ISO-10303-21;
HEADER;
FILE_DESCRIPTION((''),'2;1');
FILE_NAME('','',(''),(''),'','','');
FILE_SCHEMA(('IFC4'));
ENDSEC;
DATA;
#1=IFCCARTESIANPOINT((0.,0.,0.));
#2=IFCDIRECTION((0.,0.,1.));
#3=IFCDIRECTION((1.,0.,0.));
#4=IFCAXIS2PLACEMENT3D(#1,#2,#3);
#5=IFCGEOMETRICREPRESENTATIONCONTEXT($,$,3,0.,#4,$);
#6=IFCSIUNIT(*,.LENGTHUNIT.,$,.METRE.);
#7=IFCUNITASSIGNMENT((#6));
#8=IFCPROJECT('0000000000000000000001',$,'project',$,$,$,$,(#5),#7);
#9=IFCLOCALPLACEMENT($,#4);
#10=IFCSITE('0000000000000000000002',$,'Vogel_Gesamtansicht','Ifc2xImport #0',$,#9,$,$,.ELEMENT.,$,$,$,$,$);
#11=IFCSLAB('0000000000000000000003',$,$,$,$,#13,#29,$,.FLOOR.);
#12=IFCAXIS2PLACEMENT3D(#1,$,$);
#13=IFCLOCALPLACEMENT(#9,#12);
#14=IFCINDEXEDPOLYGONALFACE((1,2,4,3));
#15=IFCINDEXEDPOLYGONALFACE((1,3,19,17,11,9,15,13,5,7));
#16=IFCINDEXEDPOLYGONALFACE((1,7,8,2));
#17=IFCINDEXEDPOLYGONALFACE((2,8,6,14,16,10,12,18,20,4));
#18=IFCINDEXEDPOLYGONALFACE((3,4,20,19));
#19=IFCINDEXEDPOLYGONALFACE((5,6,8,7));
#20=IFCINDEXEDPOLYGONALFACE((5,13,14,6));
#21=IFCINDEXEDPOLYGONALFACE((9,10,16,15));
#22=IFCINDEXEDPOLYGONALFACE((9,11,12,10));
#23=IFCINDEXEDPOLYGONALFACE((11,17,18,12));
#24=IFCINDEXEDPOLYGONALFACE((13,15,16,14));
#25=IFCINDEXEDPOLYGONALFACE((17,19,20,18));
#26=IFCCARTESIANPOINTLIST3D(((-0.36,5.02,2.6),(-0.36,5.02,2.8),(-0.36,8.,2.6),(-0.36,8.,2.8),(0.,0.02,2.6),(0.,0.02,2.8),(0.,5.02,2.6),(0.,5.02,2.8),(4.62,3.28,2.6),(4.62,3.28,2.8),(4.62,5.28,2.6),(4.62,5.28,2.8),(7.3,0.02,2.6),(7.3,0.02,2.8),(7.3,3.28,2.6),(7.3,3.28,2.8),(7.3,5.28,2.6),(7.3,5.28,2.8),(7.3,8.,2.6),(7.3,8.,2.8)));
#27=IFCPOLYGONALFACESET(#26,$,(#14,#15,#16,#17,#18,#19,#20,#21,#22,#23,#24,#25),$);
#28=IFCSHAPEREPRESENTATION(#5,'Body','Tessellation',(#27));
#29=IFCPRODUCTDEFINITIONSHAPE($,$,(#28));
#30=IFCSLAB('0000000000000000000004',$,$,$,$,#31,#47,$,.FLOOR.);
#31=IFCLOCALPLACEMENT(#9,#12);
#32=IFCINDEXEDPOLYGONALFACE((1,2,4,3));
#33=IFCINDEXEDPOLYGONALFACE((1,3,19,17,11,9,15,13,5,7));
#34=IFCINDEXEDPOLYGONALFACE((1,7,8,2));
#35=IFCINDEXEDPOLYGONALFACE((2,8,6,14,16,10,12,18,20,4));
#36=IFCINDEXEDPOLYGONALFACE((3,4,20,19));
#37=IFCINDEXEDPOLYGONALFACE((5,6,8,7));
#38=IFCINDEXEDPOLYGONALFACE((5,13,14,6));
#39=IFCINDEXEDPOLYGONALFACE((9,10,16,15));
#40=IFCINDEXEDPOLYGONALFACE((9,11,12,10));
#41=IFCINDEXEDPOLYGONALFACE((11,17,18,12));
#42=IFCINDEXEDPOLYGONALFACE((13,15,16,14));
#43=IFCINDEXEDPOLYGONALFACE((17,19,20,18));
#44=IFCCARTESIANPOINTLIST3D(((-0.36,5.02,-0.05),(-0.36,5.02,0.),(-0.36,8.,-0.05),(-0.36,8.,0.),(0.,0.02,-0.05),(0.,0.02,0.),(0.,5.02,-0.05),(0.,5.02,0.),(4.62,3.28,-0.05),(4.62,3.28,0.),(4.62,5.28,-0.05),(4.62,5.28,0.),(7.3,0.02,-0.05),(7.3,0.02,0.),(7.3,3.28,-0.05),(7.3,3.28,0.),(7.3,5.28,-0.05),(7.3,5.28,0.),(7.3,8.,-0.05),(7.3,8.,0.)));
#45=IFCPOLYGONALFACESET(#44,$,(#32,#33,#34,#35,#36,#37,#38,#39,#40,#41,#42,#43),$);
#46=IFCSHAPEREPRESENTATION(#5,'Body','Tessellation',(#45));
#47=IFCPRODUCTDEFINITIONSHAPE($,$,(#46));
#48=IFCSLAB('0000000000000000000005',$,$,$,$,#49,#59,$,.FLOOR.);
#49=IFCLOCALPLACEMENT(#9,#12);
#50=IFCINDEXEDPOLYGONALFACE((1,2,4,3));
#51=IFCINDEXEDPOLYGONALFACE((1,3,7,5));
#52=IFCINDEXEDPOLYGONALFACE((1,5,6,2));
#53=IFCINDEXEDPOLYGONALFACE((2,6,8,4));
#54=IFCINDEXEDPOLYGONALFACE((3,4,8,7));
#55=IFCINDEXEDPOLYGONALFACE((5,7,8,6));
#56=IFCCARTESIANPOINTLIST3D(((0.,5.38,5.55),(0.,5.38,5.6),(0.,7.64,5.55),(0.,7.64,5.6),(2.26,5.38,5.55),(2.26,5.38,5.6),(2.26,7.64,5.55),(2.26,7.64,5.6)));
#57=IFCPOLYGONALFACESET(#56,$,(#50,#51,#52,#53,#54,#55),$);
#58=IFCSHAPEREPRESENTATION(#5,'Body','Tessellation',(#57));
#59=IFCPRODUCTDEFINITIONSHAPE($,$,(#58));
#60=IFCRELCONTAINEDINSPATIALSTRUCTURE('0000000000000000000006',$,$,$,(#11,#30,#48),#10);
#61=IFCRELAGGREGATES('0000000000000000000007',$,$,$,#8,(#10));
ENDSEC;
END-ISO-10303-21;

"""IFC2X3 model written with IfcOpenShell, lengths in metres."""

from ifc_helpers import new_model, si_unit, frame, origin_with_axes, place, context, project, spatial, polyline, outline, extrude, element, save


model = new_model("IFC2X3")

# Units and contexts
context_of_model = context(None, 3, precision=0.0, world=origin_with_axes())
ifc_project = project(units=[si_unit("LENGTHUNIT", "METRE")], contexts=[context_of_model])

# Site
site_placement = place(None, origin_with_axes())
site = spatial("IfcSite", under=ifc_project, at=site_placement, Name="Vogel_Gesamtansicht", Description="Ifc2xImport #0", CompositionType="ELEMENT")

# Slabs, openings
slab_1_placement = place(site_placement, frame((0.0, 5.02, 2.6), z_axis=(0.0, 0.0, 1.0), x_axis=(0.0, -1.0, 0.0)))
slab_1 = element("IfcSlab", 1, at=slab_1_placement, inside=site, PredefinedType="FLOOR", context=context_of_model, shape_type="SweptSolid", body=[
    extrude(outline(polyline([(0.0, 0.0), (5.0, 0.0), (5.0, 7.3), (-2.98, 7.3), (-2.98, -0.36), (0.0, -0.36), (0.0, 0.0)])), origin_with_axes(), (0.0, 0.0, 1.0), 0.2),
])
opening_1_placement = place(site_placement, frame((0.0, 5.02, 2.6), z_axis=(0.0, 0.0, 1.0), x_axis=(0.0, -1.0, 0.0)))
element("IfcOpeningElement", 2, at=opening_1_placement, cuts=slab_1, context=context_of_model, shape_type="SweptSolid", body=[
    extrude(outline(polyline([(1.74, 7.3), (-0.26, 7.3), (-0.26, 4.62), (1.74, 4.62), (1.74, 7.3)])), origin_with_axes(), (0.0, 0.0, 1.0), 0.2),
])
slab_2_placement = place(site_placement, frame((0.0, 5.02, -0.05), z_axis=(0.0, 0.0, 1.0), x_axis=(0.0, -1.0, 0.0)))
slab_2 = element("IfcSlab", 3, at=slab_2_placement, inside=site, PredefinedType="FLOOR", context=context_of_model, shape_type="SweptSolid", body=[
    extrude(outline(polyline([(0.0, 0.0), (5.0, 0.0), (5.0, 7.3), (-2.98, 7.3), (-2.98, -0.36), (0.0, -0.36), (0.0, 0.0)])), origin_with_axes(), (0.0, 0.0, 1.0), 0.05),
])
opening_2_placement = place(site_placement, frame((0.0, 5.02, -0.05), z_axis=(0.0, 0.0, 1.0), x_axis=(0.0, -1.0, 0.0)))
element("IfcOpeningElement", 4, at=opening_2_placement, cuts=slab_2, context=context_of_model, shape_type="SweptSolid", body=[
    extrude(outline(polyline([(1.74, 7.3), (-0.26, 7.3), (-0.26, 4.62), (1.74, 4.62), (1.74, 7.3)])), origin_with_axes(), (0.0, 0.0, 1.0), 0.05),
])

# Slab
slab_3_placement = place(site_placement, frame((2.26, 7.64, 5.55), z_axis=(0.0, 0.0, 1.0), x_axis=(-1.0, 0.0, 0.0)))
element("IfcSlab", 5, at=slab_3_placement, inside=site, PredefinedType="FLOOR", context=context_of_model, shape_type="SweptSolid", body=[
    extrude(outline(polyline([(0.0, 0.0), (2.26, 0.0), (2.26, 2.26), (0.0, 2.26), (0.0, 0.0)])), origin_with_axes(), (0.0, 0.0, 1.0), 0.05),
])

save(model, "model.ifc")
